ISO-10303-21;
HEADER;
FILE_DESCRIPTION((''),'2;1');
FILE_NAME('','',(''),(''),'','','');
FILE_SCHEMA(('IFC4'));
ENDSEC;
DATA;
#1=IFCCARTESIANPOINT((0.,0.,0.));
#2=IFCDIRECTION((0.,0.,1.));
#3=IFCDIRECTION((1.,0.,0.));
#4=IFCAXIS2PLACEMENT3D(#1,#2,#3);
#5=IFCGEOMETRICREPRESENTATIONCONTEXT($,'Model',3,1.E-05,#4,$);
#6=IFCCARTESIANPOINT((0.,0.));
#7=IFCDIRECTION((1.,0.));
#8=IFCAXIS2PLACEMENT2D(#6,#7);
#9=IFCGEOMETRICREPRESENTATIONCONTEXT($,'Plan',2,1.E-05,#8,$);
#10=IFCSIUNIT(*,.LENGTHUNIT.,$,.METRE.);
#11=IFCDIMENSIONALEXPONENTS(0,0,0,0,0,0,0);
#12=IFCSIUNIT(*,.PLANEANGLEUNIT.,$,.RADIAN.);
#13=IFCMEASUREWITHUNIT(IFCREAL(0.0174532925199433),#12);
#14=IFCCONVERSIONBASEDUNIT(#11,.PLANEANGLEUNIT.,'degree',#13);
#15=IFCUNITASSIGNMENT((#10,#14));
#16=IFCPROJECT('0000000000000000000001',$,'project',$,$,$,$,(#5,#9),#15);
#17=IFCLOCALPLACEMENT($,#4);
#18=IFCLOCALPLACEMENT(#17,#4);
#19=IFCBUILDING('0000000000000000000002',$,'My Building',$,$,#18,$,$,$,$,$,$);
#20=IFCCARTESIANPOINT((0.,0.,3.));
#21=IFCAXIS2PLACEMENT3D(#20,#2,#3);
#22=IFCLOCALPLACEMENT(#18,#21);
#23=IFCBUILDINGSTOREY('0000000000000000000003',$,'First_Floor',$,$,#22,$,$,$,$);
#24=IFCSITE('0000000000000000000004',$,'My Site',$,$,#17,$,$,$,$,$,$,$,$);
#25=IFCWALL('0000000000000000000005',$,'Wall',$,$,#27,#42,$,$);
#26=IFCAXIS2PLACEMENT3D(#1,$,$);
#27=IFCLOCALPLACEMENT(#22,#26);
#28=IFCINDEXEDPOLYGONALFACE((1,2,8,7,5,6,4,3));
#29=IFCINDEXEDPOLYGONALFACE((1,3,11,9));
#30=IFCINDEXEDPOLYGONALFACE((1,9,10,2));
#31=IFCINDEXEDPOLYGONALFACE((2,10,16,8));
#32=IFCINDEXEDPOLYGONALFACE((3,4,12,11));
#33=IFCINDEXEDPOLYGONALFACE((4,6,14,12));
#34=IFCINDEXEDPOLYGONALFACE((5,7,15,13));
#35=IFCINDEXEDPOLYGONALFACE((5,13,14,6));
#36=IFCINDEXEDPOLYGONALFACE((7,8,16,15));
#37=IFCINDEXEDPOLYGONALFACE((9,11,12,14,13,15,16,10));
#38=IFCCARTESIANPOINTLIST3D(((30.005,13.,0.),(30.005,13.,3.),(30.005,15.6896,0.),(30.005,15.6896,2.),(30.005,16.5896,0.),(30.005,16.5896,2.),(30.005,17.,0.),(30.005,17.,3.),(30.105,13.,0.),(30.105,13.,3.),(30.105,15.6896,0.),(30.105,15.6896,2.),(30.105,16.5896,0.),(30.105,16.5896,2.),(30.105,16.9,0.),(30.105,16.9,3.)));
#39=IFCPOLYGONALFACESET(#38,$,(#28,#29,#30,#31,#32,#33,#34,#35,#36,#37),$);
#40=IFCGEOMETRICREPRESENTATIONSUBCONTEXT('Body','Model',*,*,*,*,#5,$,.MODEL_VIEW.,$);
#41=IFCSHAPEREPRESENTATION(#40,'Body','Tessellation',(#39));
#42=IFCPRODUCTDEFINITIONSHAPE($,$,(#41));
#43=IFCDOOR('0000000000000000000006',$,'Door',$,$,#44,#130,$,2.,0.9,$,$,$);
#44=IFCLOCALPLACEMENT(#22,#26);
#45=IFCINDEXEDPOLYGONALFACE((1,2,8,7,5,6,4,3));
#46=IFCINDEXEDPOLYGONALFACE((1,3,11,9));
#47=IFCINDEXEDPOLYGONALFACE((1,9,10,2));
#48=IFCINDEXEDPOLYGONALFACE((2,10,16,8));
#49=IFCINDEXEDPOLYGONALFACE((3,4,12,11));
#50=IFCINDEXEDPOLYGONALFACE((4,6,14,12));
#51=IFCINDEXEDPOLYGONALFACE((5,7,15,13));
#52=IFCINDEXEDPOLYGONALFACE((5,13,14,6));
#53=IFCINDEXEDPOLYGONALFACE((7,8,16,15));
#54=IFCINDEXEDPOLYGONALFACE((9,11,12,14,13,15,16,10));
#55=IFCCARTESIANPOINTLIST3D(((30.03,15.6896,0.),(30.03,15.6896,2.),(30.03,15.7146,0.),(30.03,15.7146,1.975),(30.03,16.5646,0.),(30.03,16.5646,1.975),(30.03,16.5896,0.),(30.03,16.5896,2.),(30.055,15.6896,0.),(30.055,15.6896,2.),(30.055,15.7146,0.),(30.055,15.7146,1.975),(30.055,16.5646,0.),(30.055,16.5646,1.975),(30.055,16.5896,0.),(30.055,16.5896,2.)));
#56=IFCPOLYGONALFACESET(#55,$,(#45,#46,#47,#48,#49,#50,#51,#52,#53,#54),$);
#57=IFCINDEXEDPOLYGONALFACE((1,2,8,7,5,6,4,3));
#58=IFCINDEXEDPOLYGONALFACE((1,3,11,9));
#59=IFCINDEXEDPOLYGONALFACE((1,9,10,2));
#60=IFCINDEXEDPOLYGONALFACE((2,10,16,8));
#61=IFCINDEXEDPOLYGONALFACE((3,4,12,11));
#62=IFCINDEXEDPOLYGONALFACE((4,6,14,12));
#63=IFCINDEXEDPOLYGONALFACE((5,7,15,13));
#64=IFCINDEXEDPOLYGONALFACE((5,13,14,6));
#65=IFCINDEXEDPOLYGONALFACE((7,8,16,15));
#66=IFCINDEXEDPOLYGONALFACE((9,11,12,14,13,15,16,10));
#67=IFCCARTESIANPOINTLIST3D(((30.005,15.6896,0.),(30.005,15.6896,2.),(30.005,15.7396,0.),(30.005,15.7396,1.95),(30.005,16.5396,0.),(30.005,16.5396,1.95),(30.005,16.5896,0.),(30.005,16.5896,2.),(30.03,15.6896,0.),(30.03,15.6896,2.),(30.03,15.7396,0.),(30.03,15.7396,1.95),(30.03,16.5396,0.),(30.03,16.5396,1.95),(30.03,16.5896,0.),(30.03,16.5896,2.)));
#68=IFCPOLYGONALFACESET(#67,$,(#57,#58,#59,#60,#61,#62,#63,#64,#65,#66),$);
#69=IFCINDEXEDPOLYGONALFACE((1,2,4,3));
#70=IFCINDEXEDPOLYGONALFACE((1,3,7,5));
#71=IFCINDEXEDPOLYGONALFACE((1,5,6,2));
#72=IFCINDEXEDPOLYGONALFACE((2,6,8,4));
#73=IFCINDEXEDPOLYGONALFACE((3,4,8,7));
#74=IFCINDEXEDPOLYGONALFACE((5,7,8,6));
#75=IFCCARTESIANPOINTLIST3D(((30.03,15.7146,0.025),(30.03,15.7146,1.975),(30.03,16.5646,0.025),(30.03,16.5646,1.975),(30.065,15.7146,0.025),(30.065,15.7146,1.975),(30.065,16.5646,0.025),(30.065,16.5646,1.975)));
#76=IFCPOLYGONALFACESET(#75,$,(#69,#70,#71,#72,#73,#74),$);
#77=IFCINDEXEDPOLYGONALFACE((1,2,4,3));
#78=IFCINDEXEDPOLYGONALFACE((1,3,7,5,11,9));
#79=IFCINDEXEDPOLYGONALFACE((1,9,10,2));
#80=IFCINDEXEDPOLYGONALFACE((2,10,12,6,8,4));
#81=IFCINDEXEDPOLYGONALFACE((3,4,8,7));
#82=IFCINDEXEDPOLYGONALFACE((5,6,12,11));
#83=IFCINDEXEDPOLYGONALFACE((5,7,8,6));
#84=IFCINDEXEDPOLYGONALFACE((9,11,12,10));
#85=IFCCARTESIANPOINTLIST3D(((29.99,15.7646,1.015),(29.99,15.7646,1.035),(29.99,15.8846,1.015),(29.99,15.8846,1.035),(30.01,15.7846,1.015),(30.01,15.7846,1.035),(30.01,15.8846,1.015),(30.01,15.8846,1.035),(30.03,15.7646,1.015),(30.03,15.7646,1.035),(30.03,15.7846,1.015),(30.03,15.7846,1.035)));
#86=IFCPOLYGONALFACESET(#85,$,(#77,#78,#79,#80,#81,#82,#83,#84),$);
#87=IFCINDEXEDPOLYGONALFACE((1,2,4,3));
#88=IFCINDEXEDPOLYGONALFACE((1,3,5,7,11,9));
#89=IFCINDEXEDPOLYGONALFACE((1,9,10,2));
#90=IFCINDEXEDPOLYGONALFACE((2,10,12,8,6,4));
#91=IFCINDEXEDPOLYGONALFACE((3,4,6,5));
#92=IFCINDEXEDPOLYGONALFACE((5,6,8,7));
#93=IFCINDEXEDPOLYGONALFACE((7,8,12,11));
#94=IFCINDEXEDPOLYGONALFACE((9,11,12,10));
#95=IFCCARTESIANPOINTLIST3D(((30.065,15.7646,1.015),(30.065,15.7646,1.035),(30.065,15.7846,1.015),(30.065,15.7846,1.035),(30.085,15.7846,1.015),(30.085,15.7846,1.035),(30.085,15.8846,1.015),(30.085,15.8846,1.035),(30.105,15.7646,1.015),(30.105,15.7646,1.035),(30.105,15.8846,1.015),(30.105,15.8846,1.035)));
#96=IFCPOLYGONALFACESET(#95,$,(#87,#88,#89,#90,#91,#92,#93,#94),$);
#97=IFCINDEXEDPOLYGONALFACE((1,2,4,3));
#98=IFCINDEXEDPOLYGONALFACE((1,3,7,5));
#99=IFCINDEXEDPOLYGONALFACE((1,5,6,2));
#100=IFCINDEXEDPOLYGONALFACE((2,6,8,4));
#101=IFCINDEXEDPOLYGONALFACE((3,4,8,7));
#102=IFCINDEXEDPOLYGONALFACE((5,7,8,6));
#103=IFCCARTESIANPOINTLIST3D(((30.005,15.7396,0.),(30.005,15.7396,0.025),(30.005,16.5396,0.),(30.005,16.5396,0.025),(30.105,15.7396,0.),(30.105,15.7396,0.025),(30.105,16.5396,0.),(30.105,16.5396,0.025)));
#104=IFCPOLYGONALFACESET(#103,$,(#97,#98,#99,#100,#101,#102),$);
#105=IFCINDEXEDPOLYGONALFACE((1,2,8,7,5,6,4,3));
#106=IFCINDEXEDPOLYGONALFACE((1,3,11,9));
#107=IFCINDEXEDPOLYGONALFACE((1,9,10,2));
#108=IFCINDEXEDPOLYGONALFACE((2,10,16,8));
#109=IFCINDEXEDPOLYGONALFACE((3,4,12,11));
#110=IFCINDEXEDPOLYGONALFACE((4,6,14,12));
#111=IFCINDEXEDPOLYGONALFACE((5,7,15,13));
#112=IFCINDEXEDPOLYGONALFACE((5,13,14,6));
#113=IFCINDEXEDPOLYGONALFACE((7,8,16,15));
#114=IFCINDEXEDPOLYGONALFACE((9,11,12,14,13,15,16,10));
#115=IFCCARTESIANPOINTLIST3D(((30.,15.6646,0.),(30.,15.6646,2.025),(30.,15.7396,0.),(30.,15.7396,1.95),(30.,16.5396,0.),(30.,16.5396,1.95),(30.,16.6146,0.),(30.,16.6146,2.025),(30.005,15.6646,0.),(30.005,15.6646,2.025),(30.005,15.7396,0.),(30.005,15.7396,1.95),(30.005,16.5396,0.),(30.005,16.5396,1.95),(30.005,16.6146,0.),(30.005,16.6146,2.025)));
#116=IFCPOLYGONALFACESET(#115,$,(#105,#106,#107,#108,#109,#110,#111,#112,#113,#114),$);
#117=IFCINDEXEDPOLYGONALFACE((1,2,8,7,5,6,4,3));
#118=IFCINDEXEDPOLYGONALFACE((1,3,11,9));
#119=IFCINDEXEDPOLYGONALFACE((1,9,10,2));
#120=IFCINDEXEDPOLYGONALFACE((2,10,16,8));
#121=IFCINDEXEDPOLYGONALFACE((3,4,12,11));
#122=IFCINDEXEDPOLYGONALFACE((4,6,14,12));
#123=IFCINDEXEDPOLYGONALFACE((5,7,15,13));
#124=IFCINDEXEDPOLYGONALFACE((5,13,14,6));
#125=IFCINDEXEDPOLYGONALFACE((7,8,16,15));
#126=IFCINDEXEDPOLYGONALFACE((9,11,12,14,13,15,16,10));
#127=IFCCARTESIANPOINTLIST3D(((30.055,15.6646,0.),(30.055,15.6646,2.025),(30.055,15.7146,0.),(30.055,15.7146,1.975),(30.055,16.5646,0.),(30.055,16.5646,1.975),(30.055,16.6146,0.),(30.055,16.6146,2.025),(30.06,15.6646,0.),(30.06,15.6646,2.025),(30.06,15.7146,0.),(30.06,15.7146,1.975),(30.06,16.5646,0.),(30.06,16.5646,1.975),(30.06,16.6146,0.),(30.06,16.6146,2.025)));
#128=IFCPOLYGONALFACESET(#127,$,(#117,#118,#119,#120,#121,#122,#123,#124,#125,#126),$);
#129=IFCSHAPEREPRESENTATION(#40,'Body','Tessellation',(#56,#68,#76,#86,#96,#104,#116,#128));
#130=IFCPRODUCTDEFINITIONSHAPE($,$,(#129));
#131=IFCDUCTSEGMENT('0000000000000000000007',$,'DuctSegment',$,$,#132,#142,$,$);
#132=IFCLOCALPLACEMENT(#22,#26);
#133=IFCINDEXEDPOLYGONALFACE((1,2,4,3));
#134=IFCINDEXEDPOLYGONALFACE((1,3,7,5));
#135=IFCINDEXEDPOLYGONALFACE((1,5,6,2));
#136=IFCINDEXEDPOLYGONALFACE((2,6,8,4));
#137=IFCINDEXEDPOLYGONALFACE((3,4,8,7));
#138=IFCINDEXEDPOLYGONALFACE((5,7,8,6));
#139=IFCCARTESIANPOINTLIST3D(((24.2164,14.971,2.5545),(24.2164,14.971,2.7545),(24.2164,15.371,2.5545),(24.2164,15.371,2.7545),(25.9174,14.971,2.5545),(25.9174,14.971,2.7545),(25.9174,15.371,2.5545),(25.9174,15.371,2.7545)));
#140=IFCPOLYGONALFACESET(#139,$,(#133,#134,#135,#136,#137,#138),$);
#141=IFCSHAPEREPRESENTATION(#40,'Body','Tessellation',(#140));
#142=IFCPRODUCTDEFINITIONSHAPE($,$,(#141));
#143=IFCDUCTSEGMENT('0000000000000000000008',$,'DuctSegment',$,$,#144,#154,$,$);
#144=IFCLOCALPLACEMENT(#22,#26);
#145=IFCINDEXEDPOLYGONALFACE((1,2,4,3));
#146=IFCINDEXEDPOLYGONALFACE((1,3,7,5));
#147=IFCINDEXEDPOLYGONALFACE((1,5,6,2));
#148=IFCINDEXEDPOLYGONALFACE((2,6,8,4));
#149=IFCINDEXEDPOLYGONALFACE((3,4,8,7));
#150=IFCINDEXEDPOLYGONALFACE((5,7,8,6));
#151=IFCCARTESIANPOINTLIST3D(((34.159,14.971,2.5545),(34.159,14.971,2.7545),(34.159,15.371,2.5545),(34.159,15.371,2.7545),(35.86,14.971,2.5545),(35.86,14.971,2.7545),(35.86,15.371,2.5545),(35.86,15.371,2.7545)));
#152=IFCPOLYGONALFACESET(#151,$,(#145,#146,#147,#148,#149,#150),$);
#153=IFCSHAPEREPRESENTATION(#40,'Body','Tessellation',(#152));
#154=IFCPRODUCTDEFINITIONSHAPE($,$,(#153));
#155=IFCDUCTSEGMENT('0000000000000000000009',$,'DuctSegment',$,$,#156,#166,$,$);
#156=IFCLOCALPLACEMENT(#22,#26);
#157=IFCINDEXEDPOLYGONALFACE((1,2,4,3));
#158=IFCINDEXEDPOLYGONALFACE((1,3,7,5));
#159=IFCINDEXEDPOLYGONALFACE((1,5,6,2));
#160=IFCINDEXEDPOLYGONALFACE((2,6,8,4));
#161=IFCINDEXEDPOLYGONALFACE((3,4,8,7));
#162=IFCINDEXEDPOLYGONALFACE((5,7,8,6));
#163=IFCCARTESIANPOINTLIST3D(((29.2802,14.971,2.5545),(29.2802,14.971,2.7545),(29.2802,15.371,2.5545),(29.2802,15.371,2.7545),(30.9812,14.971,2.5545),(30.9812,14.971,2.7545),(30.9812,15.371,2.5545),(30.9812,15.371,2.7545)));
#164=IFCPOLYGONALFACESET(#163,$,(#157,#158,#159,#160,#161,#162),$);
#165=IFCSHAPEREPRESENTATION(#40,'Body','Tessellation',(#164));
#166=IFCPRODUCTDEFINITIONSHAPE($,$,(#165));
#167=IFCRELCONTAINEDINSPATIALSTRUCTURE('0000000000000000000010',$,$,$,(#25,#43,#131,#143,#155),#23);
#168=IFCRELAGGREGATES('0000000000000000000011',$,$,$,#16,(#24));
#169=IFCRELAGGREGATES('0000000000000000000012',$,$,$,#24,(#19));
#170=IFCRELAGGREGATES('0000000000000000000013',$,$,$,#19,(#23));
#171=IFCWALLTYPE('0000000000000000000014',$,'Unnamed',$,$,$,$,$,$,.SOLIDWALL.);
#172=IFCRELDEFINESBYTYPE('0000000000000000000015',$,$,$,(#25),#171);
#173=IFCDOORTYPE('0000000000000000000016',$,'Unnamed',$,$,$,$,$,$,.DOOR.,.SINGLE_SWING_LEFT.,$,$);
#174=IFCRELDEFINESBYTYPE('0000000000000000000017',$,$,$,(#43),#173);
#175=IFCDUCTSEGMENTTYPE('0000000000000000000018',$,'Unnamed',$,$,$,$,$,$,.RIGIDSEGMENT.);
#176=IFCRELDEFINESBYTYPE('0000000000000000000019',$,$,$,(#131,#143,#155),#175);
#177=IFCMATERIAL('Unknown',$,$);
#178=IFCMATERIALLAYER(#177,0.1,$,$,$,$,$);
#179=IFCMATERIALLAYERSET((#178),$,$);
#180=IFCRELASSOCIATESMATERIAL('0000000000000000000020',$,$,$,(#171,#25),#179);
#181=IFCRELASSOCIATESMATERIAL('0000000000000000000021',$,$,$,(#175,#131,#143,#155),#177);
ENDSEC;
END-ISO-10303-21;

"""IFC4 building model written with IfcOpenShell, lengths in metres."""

from ifc_helpers import new_model, entity, si_unit, converted_unit, frame, origin_with_axes, origin_2d_with_axis, place, context, subcontext, project, spatial, line, indexed_curve, rectangle, outline, extrude, shape, source, transform, mapped, material, layer, layer_set, layer_usage, material_profile, profile_set, profile_usage, type_object, type_shapes, element, fill, save


model = new_model("IFC4")

# Units and contexts
model_context = context("Model", 3, precision=1e-05, world=origin_with_axes())
plan_context = context("Plan", 2, precision=1e-05, world=origin_2d_with_axis())
body_context_1 = subcontext(model_context, "Body", "Model", "MODEL_VIEW")
body_context_2 = subcontext(plan_context, "Body", "Plan", "PLAN_VIEW")
ifc_project = project(units=[si_unit("LENGTHUNIT", "METRE"), converted_unit("PLANEANGLEUNIT", "degree", entity("IfcReal", 0.0174532925199433), si_unit("PLANEANGLEUNIT", "RADIAN"), dimensions=[0, 0, 0, 0, 0, 0, 0])], contexts=[model_context, plan_context])

# Site, building, storey
site_placement = place(None, origin_with_axes())
site = spatial("IfcSite", under=ifc_project, at=site_placement, Name="My Site")
building_placement = place(site_placement, origin_with_axes())
building = spatial("IfcBuilding", under=site, at=building_placement, Name="My Building")
storey_placement = place(building_placement, frame((0.0, 0.0, 3.0), z_axis=(0.0, 0.0, 1.0), x_axis=(1.0, 0.0, 0.0)))
storey = spatial("IfcBuildingStorey", under=building, at=storey_placement, Name="First_Floor")

# Shared definitions
ifc_material = material(Name="Unknown")
ifc_layer = layer(ifc_material, 0.1)
ifc_layer_set = layer_set([ifc_layer])
wall_type = type_object("IfcWallType", Name="Unnamed", PredefinedType="SOLIDWALL", material=ifc_layer_set)

# Shared definitions
shared_shape_1 = source(origin_with_axes(), body_context_1, "Body", "SweptSolid", [
    extrude(outline(indexed_curve([(0.0, 0.0), (0.9, 0.0), (0.9, 2.0), (0.0, 2.0)], segments=[line(1, 2, 3, 4, 1)])), frame((0.0, -0.6, 0.0), z_axis=(0.0, -1.0, 0.0), x_axis=(1.0, 0.0, 0.0)), (0.0, 0.0, -1.0), 1.2),
])
door_type = type_object("IfcDoorType", Name="Unnamed", OperationType="SINGLE_SWING_LEFT", PredefinedType="DOOR")
shared_shape_2 = source(origin_with_axes(), body_context_1, "Body", "SweptSolid", [
    extrude(outline(indexed_curve([(0.0, 0.0), (0.0, 2.0), (0.9, 2.0), (0.9, 0.0), (0.875, 0.0), (0.875, 1.975), (0.025, 1.975), (0.025, 0.0)], segments=[line(1, 2, 3, 4, 5, 6, 7, 8, 1)])), frame((0.0, 0.025, 0.0), z_axis=(0.0, -1.0, 0.0), x_axis=(1.0, 0.0, 0.0)), (0.0, 0.0, -1.0), 0.025),
    extrude(outline(indexed_curve([(0.0, 0.0), (0.0, 2.0), (0.9, 2.0), (0.9, 0.0), (0.85, 0.0), (0.85, 1.95), (0.05, 1.95), (0.05, 0.0)], segments=[line(1, 2, 3, 4, 5, 6, 7, 8, 1)])), frame((0.0, 0.0, 0.0), z_axis=(0.0, -1.0, 0.0), x_axis=(1.0, 0.0, 0.0)), (0.0, 0.0, -1.0), 0.025),
    extrude(outline(indexed_curve([(0.0, 0.0), (0.85, 0.0), (0.85, 0.035), (0.0, 0.035)], segments=[line(1, 2, 3, 4, 1)])), frame((0.025, 0.025, 0.025), z_axis=(0.0, 0.0, 1.0), x_axis=(1.0, 0.0, 0.0)), (0.0, 0.0, 1.0), 1.95),
    extrude(outline(indexed_curve([(0.0, 0.0), (0.0, -0.04), (-0.12, -0.04), (-0.12, -0.02), (-0.02, -0.02), (-0.02, 0.0)], segments=[line(1, 2, 3, 4, 5, 6, 1)])), frame((0.825, 0.025, 1.015), z_axis=(0.0, 0.0, 1.0), x_axis=(1.0, 0.0, 0.0)), (0.0, 0.0, 1.0), 0.02),
    extrude(outline(indexed_curve([(0.0, 0.0), (0.0, 0.04), (-0.12, 0.04), (-0.12, 0.02), (-0.02, 0.02), (-0.02, 0.0)], segments=[line(1, 2, 3, 4, 5, 6, 1)])), frame((0.825, 0.06, 1.015), z_axis=(0.0, 0.0, 1.0), x_axis=(1.0, 0.0, 0.0)), (0.0, 0.0, 1.0), 0.02),
    extrude(outline(indexed_curve([(0.0, 0.0), (0.8, 0.0), (0.8, 0.1), (0.0, 0.1)], segments=[line(1, 2, 3, 4, 1)])), frame((0.05, 0.0, 0.0), z_axis=(0.0, 0.0, 1.0), x_axis=(1.0, 0.0, 0.0)), (0.0, 0.0, 1.0), 0.025),
    extrude(outline(indexed_curve([(0.0, 0.0), (0.0, 2.025), (0.95, 2.025), (0.95, 0.0), (0.875, 0.0), (0.875, 1.95), (0.075, 1.95), (0.075, 0.0)], segments=[line(1, 2, 3, 4, 5, 6, 7, 8, 1)])), frame((-0.025, -0.005, 0.0), z_axis=(0.0, -1.0, 0.0), x_axis=(1.0, 0.0, 0.0)), (0.0, 0.0, -1.0), 0.005),
    extrude(outline(indexed_curve([(0.0, 0.0), (0.0, 2.025), (0.95, 2.025), (0.95, 0.0), (0.9, 0.0), (0.9, 1.975), (0.05, 1.975), (0.05, 0.0)], segments=[line(1, 2, 3, 4, 5, 6, 7, 8, 1)])), frame((-0.025, 0.05, 0.0), z_axis=(0.0, -1.0, 0.0), x_axis=(1.0, 0.0, 0.0)), (0.0, 0.0, -1.0), 0.005),
])
shared_shape_3 = source(origin_with_axes(), body_context_2, "Body", "Curve2D", [
    entity("IfcIndexedPolyCurve", entity("IfcCartesianPointList2D", [[0.0, 0.0], [0.0, 0.05], [0.025, 0.05], [0.025, 0.025], [0.05, 0.025], [0.05, 0.0]]), [entity("IfcLineIndex", [1, 2, 3, 4, 5, 6, 1])]),
    entity("IfcIndexedPolyCurve", entity("IfcCartesianPointList2D", [[0.9, 0.0], [0.9, 0.05], [0.875, 0.05], [0.875, 0.025], [0.85, 0.025], [0.85, 0.0]]), [entity("IfcLineIndex", [1, 2, 3, 4, 5, 6, 1])]),
    entity("IfcTrimmedCurve", entity("IfcEllipse", entity("IfcAxis2Placement2D", entity("IfcCartesianPoint", [0.06, 0.05]), entity("IfcDirection", [1.0, 0.0])), 0.815, 0.85), [entity("IfcCartesianPoint", [0.875, 0.05])], [entity("IfcCartesianPoint", [0.06, 0.9])], True, "CARTESIAN"),
    entity("IfcIndexedPolyCurve", entity("IfcCartesianPointList2D", [[0.025, 0.05], [0.06, 0.05], [0.06, 0.9], [0.025, 0.9]]), [entity("IfcLineIndex", [1, 2, 3, 4, 1])]),
])
type_shapes(door_type, [shared_shape_2, shared_shape_3])

# Wall, opening, door
ifc_layer_usage_1 = layer_usage(ifc_layer_set, "AXIS2", "POSITIVE", 0.0)
wall_1_placement = place(storey_placement, frame((30.005, 17.0, 0.0), z_axis=(0.0, 0.0, 1.0), x_axis=(0.0, -1.0, 0.0)))
wall_1 = element("IfcWall", 1, at=wall_1_placement, inside=storey, type_object=wall_type, material=ifc_layer_usage_1, Name="Wall", context=body_context_1, shape_type="SweptSolid", body=[
    extrude(outline(indexed_curve([(0.0, 0.0), (0.1, 0.1), (4.0, 0.1), (4.0, 0.0)], segments=[line(1, 2, 3, 4, 1)])), origin_with_axes(), (0.0, 0.0, 1.0), 3.0),
])
opening_1_placement = place(wall_1_placement, frame((0.4104, 0.0, 0.0), z_axis=(0.0, 0.0, 1.0), x_axis=(1.0, 0.0, 0.0)))
opening_1 = element("IfcOpeningElement", 2, at=opening_1_placement, cuts=wall_1, PredefinedType="OPENING", context=body_context_1, shape_type="MappedRepresentation", body=[
    mapped(shared_shape_1, transform((0.0, 0.0, 0.0), x_axis=(1.0, 0.0, 0.0), y_axis=(0.0, 1.0, 0.0), z_axis=(0.0, 0.0, 1.0), scale=1.0)),
])
door_1_placement = place(opening_1_placement, frame((0.0, 0.0, 0.0), z_axis=(0.0, 0.0, 1.0), x_axis=(1.0, 0.0, 0.0)))
door_1 = element("IfcDoor", 3, at=door_1_placement, inside=storey, type_object=door_type, Name="Door", OverallHeight=2.0, OverallWidth=0.9, shapes=[
    shape(body_context_1, "Body", "MappedRepresentation", [mapped(shared_shape_2, transform((0.0, 0.0, 0.0), x_axis=(1.0, 0.0, 0.0), y_axis=(0.0, 1.0, 0.0), z_axis=(0.0, 0.0, 1.0), scale=1.0))]),
    shape(body_context_2, "Body", "MappedRepresentation", [mapped(shared_shape_3, transform((0.0, 0.0, 0.0), x_axis=(1.0, 0.0, 0.0), y_axis=(0.0, 1.0, 0.0), z_axis=(0.0, 0.0, 1.0), scale=1.0))]),
])
fill(opening_1, door_1)

# Duct segments
ifc_material_profile_1 = material_profile(ifc_material, rectangle(XDim=0.4, YDim=0.2))
ifc_profile_set_1 = profile_set([ifc_material_profile_1])
ifc_profile_usage_1 = profile_usage(ifc_profile_set_1, cardinal=5)
duct_segment_type = type_object("IfcDuctSegmentType", Name="Unnamed", PredefinedType="RIGIDSEGMENT", material=ifc_profile_set_1)
duct_segment_1_placement = place(storey_placement, frame((24.2164, 15.171, 2.6545), z_axis=(1.0, -0.000001, 0.000001), x_axis=(0.000001, 1.0, 0.0)))
element("IfcDuctSegment", 4, at=duct_segment_1_placement, inside=storey, type_object=duct_segment_type, material=ifc_profile_usage_1, Name="DuctSegment", context=body_context_1, shape_type="SweptSolid", body=[
    extrude(rectangle(XDim=0.4, YDim=0.2), origin_with_axes(), (0.0, 0.0, 1.0), 1.701),
])
ifc_profile_usage_2 = profile_usage(ifc_profile_set_1, cardinal=5)
duct_segment_2_placement = place(storey_placement, frame((34.159, 15.171, 2.6545), z_axis=(1.0, -0.000001, 0.000001), x_axis=(0.000001, 1.0, 0.0)))
element("IfcDuctSegment", 5, at=duct_segment_2_placement, inside=storey, type_object=duct_segment_type, material=ifc_profile_usage_2, Name="DuctSegment", context=body_context_1, shape_type="SweptSolid", body=[
    extrude(rectangle(XDim=0.4, YDim=0.2), origin_with_axes(), (0.0, 0.0, 1.0), 1.701),
])
ifc_profile_usage_3 = profile_usage(ifc_profile_set_1, cardinal=5)
duct_segment_3_placement = place(storey_placement, frame((29.2802, 15.171, 2.6545), z_axis=(1.0, -0.000001, 0.000001), x_axis=(0.000001, 1.0, 0.0)))
element("IfcDuctSegment", 6, at=duct_segment_3_placement, inside=storey, type_object=duct_segment_type, material=ifc_profile_usage_3, Name="DuctSegment", context=body_context_1, shape_type="SweptSolid", body=[
    extrude(rectangle(XDim=0.4, YDim=0.2), origin_with_axes(), (0.0, 0.0, 1.0), 1.701),
])

save(model, "model.ifc")
